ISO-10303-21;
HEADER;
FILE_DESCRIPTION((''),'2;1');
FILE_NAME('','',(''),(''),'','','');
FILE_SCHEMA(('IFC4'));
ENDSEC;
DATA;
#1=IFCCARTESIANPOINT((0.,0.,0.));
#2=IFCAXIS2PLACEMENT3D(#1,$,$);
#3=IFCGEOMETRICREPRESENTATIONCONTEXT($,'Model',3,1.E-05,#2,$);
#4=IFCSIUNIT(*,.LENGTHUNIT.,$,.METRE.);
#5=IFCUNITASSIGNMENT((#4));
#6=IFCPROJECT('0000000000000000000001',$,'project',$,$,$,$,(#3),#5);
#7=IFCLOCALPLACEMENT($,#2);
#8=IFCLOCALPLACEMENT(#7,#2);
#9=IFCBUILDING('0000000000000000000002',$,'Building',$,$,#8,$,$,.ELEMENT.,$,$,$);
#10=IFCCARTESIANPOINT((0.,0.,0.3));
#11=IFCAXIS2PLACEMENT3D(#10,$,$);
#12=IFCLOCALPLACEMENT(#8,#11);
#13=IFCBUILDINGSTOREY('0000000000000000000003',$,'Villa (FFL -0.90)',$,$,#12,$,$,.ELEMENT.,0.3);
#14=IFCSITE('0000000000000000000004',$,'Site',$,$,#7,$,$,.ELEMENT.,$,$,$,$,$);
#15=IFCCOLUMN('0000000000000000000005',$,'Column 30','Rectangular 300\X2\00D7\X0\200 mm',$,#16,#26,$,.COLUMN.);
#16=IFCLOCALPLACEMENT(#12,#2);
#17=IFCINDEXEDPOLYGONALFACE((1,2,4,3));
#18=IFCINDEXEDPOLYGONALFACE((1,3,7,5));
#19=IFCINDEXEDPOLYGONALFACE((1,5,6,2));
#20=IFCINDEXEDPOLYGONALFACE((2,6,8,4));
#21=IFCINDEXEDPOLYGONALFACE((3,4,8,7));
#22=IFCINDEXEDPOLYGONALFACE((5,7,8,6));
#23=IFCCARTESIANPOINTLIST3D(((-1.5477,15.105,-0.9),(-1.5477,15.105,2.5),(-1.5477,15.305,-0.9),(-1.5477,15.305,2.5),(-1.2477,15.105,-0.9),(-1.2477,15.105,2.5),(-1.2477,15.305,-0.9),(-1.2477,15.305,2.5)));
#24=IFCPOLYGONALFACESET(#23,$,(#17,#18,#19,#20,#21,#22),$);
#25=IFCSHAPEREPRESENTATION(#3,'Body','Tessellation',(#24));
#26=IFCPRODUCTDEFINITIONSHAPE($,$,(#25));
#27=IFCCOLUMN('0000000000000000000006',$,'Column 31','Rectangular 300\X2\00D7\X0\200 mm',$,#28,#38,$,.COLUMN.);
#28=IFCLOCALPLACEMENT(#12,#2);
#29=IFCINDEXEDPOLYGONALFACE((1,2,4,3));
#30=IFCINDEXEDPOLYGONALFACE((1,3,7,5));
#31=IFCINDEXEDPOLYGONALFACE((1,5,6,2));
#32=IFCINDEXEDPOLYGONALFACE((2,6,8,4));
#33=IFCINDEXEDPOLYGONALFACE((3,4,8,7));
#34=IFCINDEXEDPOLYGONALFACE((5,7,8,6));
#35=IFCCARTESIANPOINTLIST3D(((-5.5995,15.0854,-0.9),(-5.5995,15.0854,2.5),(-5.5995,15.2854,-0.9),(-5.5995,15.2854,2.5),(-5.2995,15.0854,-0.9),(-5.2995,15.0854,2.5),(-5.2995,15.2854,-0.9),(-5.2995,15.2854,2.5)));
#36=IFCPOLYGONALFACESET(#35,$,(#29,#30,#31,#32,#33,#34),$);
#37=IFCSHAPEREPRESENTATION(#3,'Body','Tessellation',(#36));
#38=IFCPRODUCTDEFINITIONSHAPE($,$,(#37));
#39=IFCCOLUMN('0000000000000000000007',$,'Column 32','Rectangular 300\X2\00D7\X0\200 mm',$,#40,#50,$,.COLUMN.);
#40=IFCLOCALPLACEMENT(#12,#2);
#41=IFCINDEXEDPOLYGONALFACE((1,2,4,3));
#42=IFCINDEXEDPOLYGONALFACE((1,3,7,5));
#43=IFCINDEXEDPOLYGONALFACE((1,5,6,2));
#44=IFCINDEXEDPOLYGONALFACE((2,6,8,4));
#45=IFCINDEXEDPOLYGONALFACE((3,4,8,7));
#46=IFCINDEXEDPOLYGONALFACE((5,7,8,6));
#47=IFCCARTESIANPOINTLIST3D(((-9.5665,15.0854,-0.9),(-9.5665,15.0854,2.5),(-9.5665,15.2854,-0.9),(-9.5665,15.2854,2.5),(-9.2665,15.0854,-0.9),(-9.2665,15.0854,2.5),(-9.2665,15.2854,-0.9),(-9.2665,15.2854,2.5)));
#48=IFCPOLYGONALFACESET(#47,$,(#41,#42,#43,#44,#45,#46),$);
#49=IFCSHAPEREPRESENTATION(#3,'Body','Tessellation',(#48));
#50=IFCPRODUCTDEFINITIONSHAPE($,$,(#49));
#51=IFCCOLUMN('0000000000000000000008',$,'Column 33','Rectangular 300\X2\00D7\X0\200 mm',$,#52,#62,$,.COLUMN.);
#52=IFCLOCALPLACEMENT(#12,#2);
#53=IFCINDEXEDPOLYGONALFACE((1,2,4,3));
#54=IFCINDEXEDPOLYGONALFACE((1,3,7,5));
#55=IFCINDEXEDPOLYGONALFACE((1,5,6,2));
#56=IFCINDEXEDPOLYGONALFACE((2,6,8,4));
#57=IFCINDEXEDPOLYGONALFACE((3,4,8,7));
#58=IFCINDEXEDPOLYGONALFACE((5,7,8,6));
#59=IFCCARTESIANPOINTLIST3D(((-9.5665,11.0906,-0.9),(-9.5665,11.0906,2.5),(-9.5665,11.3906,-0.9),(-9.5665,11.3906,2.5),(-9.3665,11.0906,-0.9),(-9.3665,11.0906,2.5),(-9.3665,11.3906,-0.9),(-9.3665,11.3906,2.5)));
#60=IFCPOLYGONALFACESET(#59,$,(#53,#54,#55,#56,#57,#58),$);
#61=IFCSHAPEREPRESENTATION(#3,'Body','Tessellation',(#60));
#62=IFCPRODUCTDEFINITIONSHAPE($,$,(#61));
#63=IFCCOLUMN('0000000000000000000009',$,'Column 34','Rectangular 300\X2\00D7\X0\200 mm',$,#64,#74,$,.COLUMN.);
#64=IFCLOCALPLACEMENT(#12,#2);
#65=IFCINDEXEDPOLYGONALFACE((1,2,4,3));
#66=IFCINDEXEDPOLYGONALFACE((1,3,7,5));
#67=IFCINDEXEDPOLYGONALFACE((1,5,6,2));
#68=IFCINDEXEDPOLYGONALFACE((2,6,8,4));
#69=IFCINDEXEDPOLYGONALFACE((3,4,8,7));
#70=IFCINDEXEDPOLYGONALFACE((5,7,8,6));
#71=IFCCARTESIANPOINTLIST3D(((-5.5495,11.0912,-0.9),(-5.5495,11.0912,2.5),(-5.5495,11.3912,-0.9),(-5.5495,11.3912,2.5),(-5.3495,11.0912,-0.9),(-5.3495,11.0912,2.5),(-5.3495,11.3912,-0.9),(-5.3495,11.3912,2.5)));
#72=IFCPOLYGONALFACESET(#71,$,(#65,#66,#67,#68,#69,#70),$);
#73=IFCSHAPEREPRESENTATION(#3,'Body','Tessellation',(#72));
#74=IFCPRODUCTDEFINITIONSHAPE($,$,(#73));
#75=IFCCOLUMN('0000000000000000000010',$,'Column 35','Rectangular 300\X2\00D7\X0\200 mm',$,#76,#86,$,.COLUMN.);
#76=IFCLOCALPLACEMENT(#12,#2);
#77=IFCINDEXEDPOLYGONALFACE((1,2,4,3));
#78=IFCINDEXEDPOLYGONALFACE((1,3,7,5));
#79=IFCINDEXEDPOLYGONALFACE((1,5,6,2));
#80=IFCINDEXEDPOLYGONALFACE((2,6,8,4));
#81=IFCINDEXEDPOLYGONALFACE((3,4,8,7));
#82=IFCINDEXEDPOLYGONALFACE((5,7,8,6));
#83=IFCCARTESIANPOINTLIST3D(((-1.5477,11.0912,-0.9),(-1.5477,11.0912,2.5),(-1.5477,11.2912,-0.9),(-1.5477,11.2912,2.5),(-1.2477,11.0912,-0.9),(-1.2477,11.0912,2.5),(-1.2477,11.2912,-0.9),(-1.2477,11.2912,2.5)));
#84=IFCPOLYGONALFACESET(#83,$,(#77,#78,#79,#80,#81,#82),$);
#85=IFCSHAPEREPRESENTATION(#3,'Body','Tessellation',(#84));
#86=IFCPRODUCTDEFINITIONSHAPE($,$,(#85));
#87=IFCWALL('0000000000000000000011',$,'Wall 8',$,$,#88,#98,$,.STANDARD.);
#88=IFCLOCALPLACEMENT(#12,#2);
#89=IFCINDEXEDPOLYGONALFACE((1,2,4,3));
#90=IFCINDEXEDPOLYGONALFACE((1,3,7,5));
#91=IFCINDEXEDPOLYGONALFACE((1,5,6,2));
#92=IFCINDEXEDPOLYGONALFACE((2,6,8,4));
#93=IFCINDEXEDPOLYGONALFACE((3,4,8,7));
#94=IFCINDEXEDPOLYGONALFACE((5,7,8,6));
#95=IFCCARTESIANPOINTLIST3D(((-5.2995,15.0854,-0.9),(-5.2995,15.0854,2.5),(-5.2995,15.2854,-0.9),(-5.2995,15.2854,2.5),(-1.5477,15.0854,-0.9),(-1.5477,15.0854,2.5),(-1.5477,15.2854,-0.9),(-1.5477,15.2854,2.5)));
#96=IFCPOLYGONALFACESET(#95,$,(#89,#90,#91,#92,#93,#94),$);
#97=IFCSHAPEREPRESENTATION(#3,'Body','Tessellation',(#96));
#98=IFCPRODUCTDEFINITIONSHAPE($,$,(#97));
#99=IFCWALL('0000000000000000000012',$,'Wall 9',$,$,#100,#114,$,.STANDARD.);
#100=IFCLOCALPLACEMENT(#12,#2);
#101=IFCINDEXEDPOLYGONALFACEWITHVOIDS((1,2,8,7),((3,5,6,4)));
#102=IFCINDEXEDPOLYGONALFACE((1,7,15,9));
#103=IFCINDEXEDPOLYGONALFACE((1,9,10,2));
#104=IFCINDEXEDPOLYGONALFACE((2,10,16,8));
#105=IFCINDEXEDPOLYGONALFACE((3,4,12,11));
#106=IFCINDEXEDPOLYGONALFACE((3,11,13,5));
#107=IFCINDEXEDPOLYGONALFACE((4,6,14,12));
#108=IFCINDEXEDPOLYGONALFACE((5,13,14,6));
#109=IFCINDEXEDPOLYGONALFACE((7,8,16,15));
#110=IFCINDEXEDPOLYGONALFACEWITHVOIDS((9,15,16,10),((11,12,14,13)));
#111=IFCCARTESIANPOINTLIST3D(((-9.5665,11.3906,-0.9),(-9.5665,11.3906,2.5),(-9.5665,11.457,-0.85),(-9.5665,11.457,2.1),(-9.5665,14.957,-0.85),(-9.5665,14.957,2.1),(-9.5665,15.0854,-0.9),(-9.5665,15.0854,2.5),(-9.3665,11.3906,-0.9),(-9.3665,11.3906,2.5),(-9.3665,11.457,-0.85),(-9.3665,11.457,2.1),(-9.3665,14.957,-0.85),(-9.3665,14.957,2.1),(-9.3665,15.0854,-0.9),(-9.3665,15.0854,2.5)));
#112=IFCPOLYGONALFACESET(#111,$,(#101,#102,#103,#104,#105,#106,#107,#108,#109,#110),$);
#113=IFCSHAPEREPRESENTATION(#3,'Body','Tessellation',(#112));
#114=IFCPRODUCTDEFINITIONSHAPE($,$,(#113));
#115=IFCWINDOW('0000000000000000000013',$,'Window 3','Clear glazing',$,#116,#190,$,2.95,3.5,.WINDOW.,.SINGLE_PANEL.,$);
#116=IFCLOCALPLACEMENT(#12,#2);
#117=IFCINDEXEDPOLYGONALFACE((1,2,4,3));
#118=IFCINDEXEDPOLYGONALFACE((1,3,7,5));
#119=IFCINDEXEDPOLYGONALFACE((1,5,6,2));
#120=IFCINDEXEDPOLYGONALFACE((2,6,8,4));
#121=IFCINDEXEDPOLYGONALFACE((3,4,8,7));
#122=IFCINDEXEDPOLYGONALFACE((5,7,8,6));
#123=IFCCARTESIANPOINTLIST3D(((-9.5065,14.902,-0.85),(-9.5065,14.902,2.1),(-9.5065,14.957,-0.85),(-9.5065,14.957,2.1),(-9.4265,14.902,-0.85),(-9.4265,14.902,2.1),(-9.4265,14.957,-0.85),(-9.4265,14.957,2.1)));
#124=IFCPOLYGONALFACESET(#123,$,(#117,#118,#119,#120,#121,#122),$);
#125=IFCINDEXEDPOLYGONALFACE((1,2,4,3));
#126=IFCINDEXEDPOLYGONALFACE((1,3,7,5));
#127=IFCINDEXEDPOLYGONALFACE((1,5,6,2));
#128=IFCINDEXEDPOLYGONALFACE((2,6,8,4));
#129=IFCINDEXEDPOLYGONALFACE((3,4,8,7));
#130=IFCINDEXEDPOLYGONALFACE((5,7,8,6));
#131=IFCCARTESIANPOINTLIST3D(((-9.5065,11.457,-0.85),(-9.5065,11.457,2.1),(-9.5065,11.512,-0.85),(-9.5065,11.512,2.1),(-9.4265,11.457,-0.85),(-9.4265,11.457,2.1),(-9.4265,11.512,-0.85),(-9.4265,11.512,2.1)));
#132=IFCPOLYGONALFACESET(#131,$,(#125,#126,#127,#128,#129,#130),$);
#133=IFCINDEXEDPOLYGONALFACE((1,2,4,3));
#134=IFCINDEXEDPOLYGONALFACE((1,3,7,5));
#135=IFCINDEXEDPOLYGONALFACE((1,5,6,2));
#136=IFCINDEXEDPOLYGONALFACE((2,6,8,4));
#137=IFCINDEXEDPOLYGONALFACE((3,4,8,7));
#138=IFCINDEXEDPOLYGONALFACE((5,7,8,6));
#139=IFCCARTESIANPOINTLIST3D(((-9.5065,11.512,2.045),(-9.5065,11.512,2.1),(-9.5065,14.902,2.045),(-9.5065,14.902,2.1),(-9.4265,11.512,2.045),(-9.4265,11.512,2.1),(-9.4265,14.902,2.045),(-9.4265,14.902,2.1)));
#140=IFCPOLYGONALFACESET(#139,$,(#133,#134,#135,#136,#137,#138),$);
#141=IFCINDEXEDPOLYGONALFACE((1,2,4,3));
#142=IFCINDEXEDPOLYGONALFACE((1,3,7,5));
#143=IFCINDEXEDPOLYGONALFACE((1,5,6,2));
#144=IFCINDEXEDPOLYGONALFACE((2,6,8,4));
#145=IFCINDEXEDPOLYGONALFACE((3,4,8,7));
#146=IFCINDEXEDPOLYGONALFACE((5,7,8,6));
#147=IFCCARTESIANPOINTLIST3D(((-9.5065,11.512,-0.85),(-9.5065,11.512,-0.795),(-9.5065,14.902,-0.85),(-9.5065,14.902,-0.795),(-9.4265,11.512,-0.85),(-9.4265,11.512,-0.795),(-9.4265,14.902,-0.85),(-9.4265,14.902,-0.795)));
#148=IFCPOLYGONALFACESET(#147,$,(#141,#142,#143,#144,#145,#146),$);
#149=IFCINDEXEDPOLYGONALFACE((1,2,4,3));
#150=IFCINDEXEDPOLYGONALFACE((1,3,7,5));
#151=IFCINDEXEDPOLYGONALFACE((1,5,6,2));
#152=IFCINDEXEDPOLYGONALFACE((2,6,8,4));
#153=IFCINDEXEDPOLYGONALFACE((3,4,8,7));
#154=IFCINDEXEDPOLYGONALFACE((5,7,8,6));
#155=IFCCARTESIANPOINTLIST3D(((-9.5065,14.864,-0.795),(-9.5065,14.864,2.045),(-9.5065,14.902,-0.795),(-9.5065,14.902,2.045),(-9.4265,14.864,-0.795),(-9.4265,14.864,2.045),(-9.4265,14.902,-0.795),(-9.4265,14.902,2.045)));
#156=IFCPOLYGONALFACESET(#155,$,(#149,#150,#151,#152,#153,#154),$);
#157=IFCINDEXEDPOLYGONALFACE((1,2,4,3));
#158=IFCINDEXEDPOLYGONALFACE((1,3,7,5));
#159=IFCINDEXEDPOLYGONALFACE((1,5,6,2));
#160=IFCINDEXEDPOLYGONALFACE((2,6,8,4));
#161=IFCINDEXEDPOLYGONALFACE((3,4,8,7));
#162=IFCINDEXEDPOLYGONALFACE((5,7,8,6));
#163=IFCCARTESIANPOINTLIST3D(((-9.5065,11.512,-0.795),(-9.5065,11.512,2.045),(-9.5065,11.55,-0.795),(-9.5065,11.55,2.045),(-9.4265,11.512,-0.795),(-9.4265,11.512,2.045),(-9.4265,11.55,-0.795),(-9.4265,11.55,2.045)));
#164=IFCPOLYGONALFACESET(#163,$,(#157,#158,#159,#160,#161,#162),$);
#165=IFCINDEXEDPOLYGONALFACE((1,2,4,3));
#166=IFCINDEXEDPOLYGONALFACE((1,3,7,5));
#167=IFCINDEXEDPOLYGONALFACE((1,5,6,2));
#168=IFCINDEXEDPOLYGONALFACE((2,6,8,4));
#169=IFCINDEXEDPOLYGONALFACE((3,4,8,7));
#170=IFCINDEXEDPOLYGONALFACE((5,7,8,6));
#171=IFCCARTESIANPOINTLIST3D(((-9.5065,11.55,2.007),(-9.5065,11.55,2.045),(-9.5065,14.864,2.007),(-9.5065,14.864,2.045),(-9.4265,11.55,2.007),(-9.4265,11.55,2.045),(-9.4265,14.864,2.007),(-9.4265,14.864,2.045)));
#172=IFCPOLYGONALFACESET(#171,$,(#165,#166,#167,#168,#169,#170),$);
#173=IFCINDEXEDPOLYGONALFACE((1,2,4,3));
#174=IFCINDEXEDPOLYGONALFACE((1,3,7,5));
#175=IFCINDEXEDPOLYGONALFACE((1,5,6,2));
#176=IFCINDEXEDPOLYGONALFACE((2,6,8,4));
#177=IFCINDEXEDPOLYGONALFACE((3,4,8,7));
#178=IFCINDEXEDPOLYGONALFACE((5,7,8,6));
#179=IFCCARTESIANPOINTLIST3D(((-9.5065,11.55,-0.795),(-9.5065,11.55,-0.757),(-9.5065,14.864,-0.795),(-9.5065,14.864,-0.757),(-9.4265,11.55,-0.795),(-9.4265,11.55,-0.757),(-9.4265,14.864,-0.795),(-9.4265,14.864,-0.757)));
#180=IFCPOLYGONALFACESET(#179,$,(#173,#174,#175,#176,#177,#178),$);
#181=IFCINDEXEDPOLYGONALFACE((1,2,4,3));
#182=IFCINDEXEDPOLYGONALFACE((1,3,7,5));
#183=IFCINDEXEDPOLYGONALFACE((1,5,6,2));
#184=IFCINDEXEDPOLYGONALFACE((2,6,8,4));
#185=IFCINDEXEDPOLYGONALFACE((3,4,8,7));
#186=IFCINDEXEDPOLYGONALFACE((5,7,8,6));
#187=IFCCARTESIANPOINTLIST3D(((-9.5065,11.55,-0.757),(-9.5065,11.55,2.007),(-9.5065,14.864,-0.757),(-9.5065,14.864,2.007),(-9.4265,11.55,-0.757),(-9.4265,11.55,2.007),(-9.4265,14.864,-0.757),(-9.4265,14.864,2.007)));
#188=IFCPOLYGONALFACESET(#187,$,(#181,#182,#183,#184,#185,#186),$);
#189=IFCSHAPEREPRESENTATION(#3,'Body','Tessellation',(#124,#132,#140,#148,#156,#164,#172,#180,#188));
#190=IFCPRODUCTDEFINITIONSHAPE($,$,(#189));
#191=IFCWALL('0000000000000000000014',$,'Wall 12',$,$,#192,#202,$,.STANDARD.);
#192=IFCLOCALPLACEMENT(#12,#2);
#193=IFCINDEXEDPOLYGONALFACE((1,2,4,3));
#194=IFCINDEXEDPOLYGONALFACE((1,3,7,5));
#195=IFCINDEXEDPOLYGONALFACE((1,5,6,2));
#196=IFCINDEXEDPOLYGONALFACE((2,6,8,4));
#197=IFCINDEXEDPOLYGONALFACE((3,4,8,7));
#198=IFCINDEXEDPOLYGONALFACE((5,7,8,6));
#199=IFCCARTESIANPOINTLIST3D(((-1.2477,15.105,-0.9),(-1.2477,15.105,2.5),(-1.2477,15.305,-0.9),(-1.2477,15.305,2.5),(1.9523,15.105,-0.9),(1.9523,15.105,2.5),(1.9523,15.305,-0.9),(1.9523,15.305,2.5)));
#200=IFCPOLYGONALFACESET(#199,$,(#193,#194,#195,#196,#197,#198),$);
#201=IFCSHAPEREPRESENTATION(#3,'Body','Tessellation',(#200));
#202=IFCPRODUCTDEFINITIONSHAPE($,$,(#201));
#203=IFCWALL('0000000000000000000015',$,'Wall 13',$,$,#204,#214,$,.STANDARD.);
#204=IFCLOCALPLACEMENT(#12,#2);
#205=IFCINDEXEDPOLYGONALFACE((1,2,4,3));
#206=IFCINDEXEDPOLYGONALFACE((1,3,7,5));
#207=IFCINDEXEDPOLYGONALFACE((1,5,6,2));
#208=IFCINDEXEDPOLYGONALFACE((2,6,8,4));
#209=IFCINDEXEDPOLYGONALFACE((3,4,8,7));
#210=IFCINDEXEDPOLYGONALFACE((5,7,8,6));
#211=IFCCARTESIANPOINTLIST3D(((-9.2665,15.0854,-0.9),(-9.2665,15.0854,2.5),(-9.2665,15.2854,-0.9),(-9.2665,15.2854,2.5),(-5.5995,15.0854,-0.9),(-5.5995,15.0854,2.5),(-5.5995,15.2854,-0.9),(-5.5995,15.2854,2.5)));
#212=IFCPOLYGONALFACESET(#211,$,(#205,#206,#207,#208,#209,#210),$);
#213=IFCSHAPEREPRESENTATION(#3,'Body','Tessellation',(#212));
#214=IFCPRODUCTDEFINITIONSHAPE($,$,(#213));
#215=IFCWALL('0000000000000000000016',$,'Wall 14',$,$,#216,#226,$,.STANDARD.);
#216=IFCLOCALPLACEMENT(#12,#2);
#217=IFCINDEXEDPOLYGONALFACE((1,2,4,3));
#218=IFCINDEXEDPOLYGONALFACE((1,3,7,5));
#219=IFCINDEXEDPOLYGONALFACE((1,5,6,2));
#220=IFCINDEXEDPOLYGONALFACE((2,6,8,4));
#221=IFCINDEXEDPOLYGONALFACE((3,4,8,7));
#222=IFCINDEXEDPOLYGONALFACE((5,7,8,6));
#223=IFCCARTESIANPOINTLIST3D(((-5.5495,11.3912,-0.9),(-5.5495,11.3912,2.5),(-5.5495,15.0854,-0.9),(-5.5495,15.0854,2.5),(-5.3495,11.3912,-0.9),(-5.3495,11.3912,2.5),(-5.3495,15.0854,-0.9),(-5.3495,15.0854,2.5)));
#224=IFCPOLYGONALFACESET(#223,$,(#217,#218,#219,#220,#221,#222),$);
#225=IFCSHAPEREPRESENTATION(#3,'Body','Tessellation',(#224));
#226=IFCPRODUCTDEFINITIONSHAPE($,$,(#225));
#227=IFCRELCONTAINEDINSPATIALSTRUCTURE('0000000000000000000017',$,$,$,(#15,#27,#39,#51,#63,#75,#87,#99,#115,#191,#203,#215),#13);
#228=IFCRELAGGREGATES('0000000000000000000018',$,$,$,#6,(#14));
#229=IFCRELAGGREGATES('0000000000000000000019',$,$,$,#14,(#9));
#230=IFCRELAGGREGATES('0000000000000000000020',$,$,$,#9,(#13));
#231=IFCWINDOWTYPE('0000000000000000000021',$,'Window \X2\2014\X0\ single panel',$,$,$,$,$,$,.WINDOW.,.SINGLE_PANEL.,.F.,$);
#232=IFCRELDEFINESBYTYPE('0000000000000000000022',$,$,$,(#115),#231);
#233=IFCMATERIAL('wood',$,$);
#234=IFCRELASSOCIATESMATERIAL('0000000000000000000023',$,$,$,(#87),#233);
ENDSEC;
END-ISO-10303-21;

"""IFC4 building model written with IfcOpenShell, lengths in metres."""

from ifc_helpers import new_model, si_unit, frame, frame_2d, origin, place, context, project, spatial, polyline, rectangle, outline, extrude, material, type_object, element, fill, save


model = new_model("IFC4")

# Units and contexts
model_context = context("Model", 3, precision=1e-05, world=origin())
ifc_project = project(units=[si_unit("LENGTHUNIT", "METRE")], contexts=[model_context])

# Site, building, storey
site_placement = place(None, origin())
site = spatial("IfcSite", under=ifc_project, at=site_placement, Name="Site", CompositionType="ELEMENT")
building_placement = place(site_placement, origin())
building = spatial("IfcBuilding", under=site, at=building_placement, Name="Building", CompositionType="ELEMENT")
storey_placement = place(building_placement, frame((0.0, 0.0, 0.3)))
storey = spatial("IfcBuildingStorey", under=building, at=storey_placement, Name="Villa (FFL -0.90)", CompositionType="ELEMENT", Elevation=0.3)

# Columns
for number, where, z_axis, x_axis, name in (
    (1, (-1.3977, 15.205, -0.9), (0.0, 0.0, 1.0), (1.0, 0.0, 0.0), "Column 30"),
    (2, (-5.4495, 15.1854, -0.9), (0.0, 0.0, 1.0), (1.0, 0.0, 0.0), "Column 31"),
    (3, (-9.4165, 15.1854, -0.9), (0.0, 0.0, 1.0), (1.0, 0.0, 0.0), "Column 32"),
    (4, (-9.4665, 11.2406, -0.9), (0.0, 0.0, 1.0), (0.0, 1.0, 0.0), "Column 33"),
    (5, (-5.4495, 11.2412, -0.9), (0.0, 0.0, 1.0), (0.0, 1.0, 0.0), "Column 34"),
    (6, (-1.3977, 11.1912, -0.9), (0.0, 0.0, 1.0), (1.0, 0.0, 0.0), "Column 35"),
):
    element("IfcColumn", number, at=place(storey_placement, frame(where, z_axis=z_axis, x_axis=x_axis)), inside=storey, Name=name, Description="Rectangular 300×200 mm", PredefinedType="COLUMN", context=model_context, shape_type="SweptSolid", body=[
        extrude(outline(polyline([(-0.15, -0.1), (0.15, -0.1), (0.15, 0.1), (-0.15, 0.1), (-0.15, -0.1)])), origin(), (0.0, 0.0, 1.0), 3.4),
    ])

# Wall
ifc_material = material(Name="wood")
wall_1_placement = place(storey_placement, frame((-5.2995, 15.1854, -0.9), z_axis=(0.0, 0.0, 1.0), x_axis=(1.0, 0.0, 0.0)))
element("IfcWall", 7, at=wall_1_placement, inside=storey, material=ifc_material, Name="Wall 8", PredefinedType="STANDARD", context=model_context, shape_type="SweptSolid", body=[
    extrude(rectangle(XDim=3.7518, YDim=0.2, at=frame_2d((1.8759, 0.0))), origin(), (0.0, 0.0, 1.0), 3.4),
])

# Wall, opening, window
wall_2_placement = place(storey_placement, frame((-9.4665, 15.0854, -0.9), z_axis=(0.0, 0.0, 1.0), x_axis=(0.0, -1.0, 0.0)))
wall_2 = element("IfcWall", 8, at=wall_2_placement, inside=storey, Name="Wall 9", PredefinedType="STANDARD", context=model_context, shape_type="SweptSolid", body=[
    extrude(rectangle(XDim=3.6948, YDim=0.2, at=frame_2d((1.8474, 0.0))), origin(), (0.0, 0.0, 1.0), 3.4),
])
opening_1_placement = place(storey_placement, frame((-9.4665, 14.957, -0.85), z_axis=(0.0, 0.0, 1.0), x_axis=(0.0, -1.0, 0.0)))
opening_1 = element("IfcOpeningElement", 9, at=opening_1_placement, cuts=wall_2, PredefinedType="OPENING", context=model_context, shape_type="SweptSolid", body=[
    extrude(rectangle(XDim=3.5, YDim=0.26, at=frame_2d((1.75, 0.0))), origin(), (0.0, 0.0, 1.0), 2.95),
])
window_type = type_object("IfcWindowType", Name="Window — single panel", ParameterTakesPrecedence=False, PartitioningType="SINGLE_PANEL", PredefinedType="WINDOW")
window_placement = place(storey_placement, frame((-9.4665, 14.957, -0.85), z_axis=(0.0, 0.0, 1.0), x_axis=(0.0, -1.0, 0.0)))
window = element("IfcWindow", 10, at=window_placement, inside=storey, type_object=window_type, Name="Window 3", Description="Clear glazing", OverallHeight=2.95, OverallWidth=3.5, PartitioningType="SINGLE_PANEL", PredefinedType="WINDOW", context=model_context, shape_type="SweptSolid", body=[
    extrude(rectangle(XDim=0.055, YDim=0.08, at=frame_2d((0.0275, 0.0))), origin(), (0.0, 0.0, 1.0), 2.95),
    extrude(rectangle(XDim=0.055, YDim=0.08, at=frame_2d((3.4725, 0.0))), origin(), (0.0, 0.0, 1.0), 2.95),
    extrude(rectangle(XDim=3.39, YDim=0.08, at=frame_2d((1.75, 0.0))), frame((0.0, 0.0, 2.895)), (0.0, 0.0, 1.0), 0.055),
    extrude(rectangle(XDim=3.39, YDim=0.08, at=frame_2d((1.75, 0.0))), origin(), (0.0, 0.0, 1.0), 0.055),
    extrude(rectangle(XDim=0.038, YDim=0.08, at=frame_2d((0.074, 0.0))), frame((0.0, 0.0, 0.055)), (0.0, 0.0, 1.0), 2.84),
    extrude(rectangle(XDim=0.038, YDim=0.08, at=frame_2d((3.426, 0.0))), frame((0.0, 0.0, 0.055)), (0.0, 0.0, 1.0), 2.84),
    extrude(rectangle(XDim=3.314, YDim=0.08, at=frame_2d((1.75, 0.0))), frame((0.0, 0.0, 2.857)), (0.0, 0.0, 1.0), 0.038),
    extrude(rectangle(XDim=3.314, YDim=0.08, at=frame_2d((1.75, 0.0))), frame((0.0, 0.0, 0.055)), (0.0, 0.0, 1.0), 0.038),
    extrude(rectangle(XDim=3.314, YDim=0.08, at=frame_2d((1.75, 0.0))), frame((0.0, 0.0, 0.093)), (0.0, 0.0, 1.0), 2.764),
])
fill(opening_1, window)

# Walls
wall_3_placement = place(storey_placement, frame((-1.2477, 15.205, -0.9), z_axis=(0.0, 0.0, 1.0), x_axis=(1.0, 0.0, 0.0)))
element("IfcWall", 11, at=wall_3_placement, inside=storey, Name="Wall 12", PredefinedType="STANDARD", context=model_context, shape_type="SweptSolid", body=[
    extrude(rectangle(XDim=3.2, YDim=0.2, at=frame_2d((1.6, 0.0))), origin(), (0.0, 0.0, 1.0), 3.4),
])
wall_4_placement = place(storey_placement, frame((-9.2665, 15.1854, -0.9), z_axis=(0.0, 0.0, 1.0), x_axis=(1.0, 0.0, 0.0)))
element("IfcWall", 12, at=wall_4_placement, inside=storey, Name="Wall 13", PredefinedType="STANDARD", context=model_context, shape_type="SweptSolid", body=[
    extrude(rectangle(XDim=3.667, YDim=0.2, at=frame_2d((1.8335, 0.0))), origin(), (0.0, 0.0, 1.0), 3.4),
])
wall_5_placement = place(storey_placement, frame((-5.4495, 11.3912, -0.9), z_axis=(0.0, 0.0, 1.0), x_axis=(0.0, 1.0, 0.0)))
element("IfcWall", 13, at=wall_5_placement, inside=storey, Name="Wall 14", PredefinedType="STANDARD", context=model_context, shape_type="SweptSolid", body=[
    extrude(rectangle(XDim=3.6942, YDim=0.2, at=frame_2d((1.8471, 0.0))), origin(), (0.0, 0.0, 1.0), 3.4),
])

save(model, "model.ifc")
